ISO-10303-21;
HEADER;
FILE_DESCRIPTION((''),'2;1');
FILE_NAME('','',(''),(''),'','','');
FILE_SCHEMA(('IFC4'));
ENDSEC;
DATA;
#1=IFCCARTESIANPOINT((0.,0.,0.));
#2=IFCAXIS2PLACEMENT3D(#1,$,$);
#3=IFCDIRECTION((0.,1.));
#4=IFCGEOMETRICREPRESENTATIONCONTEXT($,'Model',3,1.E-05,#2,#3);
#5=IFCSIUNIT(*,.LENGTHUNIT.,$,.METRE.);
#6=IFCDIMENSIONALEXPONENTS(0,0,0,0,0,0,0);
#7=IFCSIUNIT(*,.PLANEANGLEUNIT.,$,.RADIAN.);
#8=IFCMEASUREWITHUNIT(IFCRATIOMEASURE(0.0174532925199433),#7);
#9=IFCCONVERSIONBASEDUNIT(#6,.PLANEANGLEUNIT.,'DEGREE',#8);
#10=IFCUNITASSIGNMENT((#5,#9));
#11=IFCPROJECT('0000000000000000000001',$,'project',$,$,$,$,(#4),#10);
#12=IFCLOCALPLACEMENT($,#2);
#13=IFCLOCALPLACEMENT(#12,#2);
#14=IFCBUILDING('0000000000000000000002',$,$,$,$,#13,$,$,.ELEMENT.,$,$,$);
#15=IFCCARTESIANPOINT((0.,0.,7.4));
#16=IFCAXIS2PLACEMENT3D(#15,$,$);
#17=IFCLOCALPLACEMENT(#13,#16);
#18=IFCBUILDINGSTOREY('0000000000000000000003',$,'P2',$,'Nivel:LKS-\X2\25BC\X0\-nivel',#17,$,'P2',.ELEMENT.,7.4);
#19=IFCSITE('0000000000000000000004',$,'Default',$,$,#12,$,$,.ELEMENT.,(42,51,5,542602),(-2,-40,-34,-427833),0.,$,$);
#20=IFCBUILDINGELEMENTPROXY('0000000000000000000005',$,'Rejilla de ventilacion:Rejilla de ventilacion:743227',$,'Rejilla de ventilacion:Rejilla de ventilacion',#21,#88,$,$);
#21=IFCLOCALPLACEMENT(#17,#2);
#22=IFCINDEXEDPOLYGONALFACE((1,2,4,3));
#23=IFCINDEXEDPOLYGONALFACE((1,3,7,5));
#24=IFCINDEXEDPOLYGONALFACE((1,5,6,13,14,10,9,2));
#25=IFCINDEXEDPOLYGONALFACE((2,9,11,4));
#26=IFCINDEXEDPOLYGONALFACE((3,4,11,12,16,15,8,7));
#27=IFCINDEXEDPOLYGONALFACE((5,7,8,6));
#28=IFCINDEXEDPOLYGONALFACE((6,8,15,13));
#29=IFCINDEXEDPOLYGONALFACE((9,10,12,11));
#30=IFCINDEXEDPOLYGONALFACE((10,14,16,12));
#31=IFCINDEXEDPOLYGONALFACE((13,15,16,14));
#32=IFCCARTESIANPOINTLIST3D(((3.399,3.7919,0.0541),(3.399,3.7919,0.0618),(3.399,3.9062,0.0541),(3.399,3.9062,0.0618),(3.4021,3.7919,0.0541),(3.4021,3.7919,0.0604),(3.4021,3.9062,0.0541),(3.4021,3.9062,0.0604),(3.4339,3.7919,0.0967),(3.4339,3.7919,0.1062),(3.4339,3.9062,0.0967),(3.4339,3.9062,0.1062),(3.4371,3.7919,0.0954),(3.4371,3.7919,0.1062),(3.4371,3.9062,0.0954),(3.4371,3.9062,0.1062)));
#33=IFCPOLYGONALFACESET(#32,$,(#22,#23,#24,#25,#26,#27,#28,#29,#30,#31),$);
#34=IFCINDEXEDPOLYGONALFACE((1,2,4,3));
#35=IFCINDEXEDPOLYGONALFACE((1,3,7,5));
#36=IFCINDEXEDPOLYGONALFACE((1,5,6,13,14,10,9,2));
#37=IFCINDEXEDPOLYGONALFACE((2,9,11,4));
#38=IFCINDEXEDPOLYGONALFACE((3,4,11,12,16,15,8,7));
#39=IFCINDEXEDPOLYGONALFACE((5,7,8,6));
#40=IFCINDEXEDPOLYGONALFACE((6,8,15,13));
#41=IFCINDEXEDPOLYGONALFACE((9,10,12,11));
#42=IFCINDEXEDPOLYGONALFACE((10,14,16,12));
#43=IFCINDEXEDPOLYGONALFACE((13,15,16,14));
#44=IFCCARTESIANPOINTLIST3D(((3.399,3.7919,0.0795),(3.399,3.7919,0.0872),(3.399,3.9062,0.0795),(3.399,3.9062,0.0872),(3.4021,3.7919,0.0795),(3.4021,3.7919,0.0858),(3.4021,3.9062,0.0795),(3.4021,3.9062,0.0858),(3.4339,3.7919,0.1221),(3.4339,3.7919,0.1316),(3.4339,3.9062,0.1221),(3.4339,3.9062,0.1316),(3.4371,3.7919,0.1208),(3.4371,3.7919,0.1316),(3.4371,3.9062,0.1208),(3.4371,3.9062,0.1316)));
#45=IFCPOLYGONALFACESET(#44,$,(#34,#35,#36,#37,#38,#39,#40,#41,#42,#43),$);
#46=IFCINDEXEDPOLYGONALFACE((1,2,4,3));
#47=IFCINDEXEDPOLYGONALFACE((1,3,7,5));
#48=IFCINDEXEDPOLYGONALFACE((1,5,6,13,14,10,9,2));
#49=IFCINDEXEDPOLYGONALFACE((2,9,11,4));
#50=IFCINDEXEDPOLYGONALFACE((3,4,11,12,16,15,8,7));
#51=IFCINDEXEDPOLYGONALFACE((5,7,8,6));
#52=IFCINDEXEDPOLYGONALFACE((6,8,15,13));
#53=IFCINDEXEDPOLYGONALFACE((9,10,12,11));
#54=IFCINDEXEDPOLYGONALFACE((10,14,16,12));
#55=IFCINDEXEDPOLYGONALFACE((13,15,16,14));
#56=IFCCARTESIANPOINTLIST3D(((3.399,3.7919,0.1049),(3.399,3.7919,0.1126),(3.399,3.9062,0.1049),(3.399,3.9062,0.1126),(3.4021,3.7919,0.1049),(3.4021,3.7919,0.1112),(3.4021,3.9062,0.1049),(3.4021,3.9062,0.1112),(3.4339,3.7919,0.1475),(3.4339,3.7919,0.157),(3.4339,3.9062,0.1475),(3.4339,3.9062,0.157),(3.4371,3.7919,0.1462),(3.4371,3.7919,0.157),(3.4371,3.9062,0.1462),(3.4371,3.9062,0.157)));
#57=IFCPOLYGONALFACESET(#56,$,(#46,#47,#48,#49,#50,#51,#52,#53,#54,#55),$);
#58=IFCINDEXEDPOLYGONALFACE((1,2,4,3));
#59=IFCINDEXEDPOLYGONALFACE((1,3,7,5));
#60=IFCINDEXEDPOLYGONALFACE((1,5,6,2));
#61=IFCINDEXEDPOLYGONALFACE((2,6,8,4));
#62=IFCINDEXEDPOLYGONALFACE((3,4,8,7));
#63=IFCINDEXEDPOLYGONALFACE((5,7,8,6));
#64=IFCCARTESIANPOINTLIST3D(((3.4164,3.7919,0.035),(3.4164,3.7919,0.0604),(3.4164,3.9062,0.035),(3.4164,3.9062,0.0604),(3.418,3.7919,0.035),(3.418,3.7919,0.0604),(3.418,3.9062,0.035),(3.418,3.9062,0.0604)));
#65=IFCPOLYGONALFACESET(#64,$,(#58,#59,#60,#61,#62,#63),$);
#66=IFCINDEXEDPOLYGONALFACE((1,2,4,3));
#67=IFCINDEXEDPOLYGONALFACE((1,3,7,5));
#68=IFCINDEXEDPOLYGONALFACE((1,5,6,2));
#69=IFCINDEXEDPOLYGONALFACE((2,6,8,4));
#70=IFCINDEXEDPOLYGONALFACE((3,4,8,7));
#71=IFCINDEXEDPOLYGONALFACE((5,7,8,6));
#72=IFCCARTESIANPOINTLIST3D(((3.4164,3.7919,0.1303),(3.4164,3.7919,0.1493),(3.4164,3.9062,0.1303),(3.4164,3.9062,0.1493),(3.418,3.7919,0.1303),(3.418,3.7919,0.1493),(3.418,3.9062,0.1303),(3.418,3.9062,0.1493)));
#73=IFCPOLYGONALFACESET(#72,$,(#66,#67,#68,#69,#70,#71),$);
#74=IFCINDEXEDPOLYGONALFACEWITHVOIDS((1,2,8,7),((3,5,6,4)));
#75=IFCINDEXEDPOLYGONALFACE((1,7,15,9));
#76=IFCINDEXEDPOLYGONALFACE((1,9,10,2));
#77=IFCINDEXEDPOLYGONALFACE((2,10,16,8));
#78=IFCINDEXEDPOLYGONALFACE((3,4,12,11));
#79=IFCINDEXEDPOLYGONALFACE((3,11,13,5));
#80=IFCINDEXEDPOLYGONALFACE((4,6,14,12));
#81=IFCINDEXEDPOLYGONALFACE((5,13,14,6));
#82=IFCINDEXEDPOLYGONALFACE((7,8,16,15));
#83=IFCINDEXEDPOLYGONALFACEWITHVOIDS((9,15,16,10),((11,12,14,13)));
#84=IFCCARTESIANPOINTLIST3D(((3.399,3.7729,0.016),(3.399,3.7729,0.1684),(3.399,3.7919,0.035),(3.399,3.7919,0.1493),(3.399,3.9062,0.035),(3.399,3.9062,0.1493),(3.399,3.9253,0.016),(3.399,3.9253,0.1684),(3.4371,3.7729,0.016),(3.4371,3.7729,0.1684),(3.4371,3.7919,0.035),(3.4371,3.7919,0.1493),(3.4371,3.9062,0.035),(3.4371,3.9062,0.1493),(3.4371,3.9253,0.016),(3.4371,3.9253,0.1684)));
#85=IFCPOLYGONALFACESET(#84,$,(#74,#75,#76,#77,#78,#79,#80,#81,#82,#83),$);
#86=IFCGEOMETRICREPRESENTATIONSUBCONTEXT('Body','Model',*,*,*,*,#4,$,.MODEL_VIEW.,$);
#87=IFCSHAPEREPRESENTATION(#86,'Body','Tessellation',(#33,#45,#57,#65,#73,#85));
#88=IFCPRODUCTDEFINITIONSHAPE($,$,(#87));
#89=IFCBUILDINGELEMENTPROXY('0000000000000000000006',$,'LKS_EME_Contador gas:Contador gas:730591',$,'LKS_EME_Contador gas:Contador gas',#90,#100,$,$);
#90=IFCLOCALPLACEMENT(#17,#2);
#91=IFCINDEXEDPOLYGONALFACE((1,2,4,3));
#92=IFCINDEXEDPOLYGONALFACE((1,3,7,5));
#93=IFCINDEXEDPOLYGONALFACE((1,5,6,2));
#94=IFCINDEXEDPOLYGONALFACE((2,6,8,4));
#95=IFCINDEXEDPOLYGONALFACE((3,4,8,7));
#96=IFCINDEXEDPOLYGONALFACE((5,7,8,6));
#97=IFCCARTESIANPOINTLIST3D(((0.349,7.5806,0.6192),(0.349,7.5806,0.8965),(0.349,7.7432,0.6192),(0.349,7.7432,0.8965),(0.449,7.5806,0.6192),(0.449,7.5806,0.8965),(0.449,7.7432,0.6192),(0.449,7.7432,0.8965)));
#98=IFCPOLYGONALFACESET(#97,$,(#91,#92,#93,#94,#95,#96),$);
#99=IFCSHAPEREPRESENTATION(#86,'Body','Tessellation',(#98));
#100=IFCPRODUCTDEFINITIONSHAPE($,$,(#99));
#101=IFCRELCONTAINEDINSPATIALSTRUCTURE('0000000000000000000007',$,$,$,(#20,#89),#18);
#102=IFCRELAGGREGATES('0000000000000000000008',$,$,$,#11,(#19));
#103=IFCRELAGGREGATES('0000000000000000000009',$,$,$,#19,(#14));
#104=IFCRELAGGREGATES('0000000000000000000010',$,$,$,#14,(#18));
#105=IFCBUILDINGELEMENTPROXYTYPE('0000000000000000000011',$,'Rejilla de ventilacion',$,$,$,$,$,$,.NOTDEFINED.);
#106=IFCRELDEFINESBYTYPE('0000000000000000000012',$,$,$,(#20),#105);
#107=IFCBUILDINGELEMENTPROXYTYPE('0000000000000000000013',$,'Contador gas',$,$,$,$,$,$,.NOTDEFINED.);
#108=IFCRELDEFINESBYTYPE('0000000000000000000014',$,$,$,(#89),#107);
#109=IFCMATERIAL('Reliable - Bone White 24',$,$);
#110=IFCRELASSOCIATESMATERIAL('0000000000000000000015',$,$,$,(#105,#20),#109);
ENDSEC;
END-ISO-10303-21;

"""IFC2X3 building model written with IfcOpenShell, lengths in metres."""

from ifc_helpers import new_model, entity, si_unit, converted_unit, direction, frame, frame_2d, origin, origin_2d_with_axis, place, context, subcontext, project, spatial, polyline, rectangle, outline, extrude, source, transform, mapped, material, type_object, type_shapes, element, save


model = new_model("IFC2X3")

# Units and contexts
model_context = context("Model", 3, precision=1e-05, world=origin(), true_north=direction((0.0, 1.0)))
body_context = subcontext(model_context, "Body", "Model", "MODEL_VIEW")
ifc_project = project(units=[si_unit("LENGTHUNIT", "METRE"), converted_unit("PLANEANGLEUNIT", "DEGREE", entity("IfcRatioMeasure", 0.0174532925199433), si_unit("PLANEANGLEUNIT", "RADIAN"), dimensions=[0, 0, 0, 0, 0, 0, 0])], contexts=[model_context])

# Site, building, storey
site_placement = place(None, origin())
site = spatial("IfcSite", under=ifc_project, at=site_placement, Name="Default", CompositionType="ELEMENT", RefLatitude=(42, 51, 5, 542602), RefLongitude=(-2, -40, -34, -427833), RefElevation=0.0)
building_placement = place(site_placement, origin())
building = spatial("IfcBuilding", under=site, at=building_placement, CompositionType="ELEMENT")
storey_placement = place(building_placement, frame((0.0, 0.0, 7.4)))
storey = spatial("IfcBuildingStorey", under=building, at=storey_placement, Name="P2", ObjectType="Nivel:LKS-▼-nivel", LongName="P2", CompositionType="ELEMENT", Elevation=7.4)

# Building element proxies
ifc_material_1 = material(Name="Reliable - Bone White 24")
building_element_proxy_type_1 = type_object("IfcBuildingElementProxyType", Name="Rejilla de ventilacion", PredefinedType="NOTDEFINED", material=ifc_material_1)
shared_shape_1 = source(origin(), body_context, "Body", "SweptSolid", [
    extrude(outline(polyline([(0.0173, 0.0159), (0.0269, 0.0159), (0.0269, 0.0191), (0.016, 0.0191), (-0.0189, -0.0159), (-0.0253, -0.0159), (-0.0253, -0.019), (-0.0176, -0.019), (0.0173, 0.0159)])), frame((-0.0571, 0.1, 1.435), z_axis=(1.0, 0.0, 0.0), x_axis=(0.0, 0.0, 1.0)), (0.0, 0.0, 1.0), 0.1143),
    extrude(outline(polyline([(0.0173, 0.0159), (0.0269, 0.0159), (0.0269, 0.0191), (0.016, 0.0191), (-0.0189, -0.0159), (-0.0253, -0.0159), (-0.0253, -0.019), (-0.0176, -0.019), (0.0173, 0.0159)])), frame((-0.0571, 0.1, 1.4604), z_axis=(1.0, 0.0, 0.0), x_axis=(0.0, 0.0, 1.0)), (0.0, 0.0, 1.0), 0.1143),
    extrude(outline(polyline([(0.0173, 0.0159), (0.0269, 0.0159), (0.0269, 0.0191), (0.016, 0.0191), (-0.0189, -0.0159), (-0.0253, -0.0159), (-0.0253, -0.019), (-0.0176, -0.019), (0.0173, 0.0159)])), frame((-0.0571, 0.1, 1.4858), z_axis=(1.0, 0.0, 0.0), x_axis=(0.0, 0.0, 1.0)), (0.0, 0.0, 1.0), 0.1143),
    extrude(rectangle(XDim=0.1143, YDim=0.0016, at=frame_2d((0.0, 0.0), x_axis=(1.0, 0.0))), frame((0.0, 0.1007, 1.3906), z_axis=(0.0, 0.0, 1.0), x_axis=(-1.0, 0.0, 0.0)), (0.0, 0.0, 1.0), 0.0254),
    extrude(rectangle(XDim=0.1143, YDim=0.0016, at=frame_2d((0.0, 0.0), x_axis=(1.0, 0.0))), frame((0.0, 0.1007, 1.4859), z_axis=(0.0, 0.0, 1.0), x_axis=(-1.0, 0.0, 0.0)), (0.0, 0.0, 1.0), 0.0191),
    extrude(outline(polyline([(-0.0762, -0.0762), (0.0762, -0.0762), (0.0762, 0.0762), (-0.0762, 0.0762), (-0.0762, -0.0762)]), holes=[polyline([(-0.0572, -0.0572), (-0.0572, 0.0572), (0.0572, 0.0572), (0.0572, -0.0572), (-0.0572, -0.0572)])]), frame((0.0, 0.0809, 1.4478), z_axis=(0.0, 1.0, 0.0), x_axis=(0.0, 0.0, 1.0)), (0.0, 0.0, 1.0), 0.0381),
])
type_shapes(building_element_proxy_type_1, [shared_shape_1])
proxy_1_placement = place(storey_placement, frame((3.518, 3.8491, -1.3556), z_axis=(0.0, 0.0, 1.0), x_axis=(0.0, 1.0, 0.0)))
element("IfcBuildingElementProxy", 1, at=proxy_1_placement, inside=storey, type_object=building_element_proxy_type_1, material=ifc_material_1, Name="Rejilla de ventilacion:Rejilla de ventilacion:743227", ObjectType="Rejilla de ventilacion:Rejilla de ventilacion", context=body_context, shape_type="MappedRepresentation", body=[
    mapped(shared_shape_1, transform((0.0, 0.0, 0.0), scale=1.0)),
])
building_element_proxy_type_2 = type_object("IfcBuildingElementProxyType", Name="Contador gas", PredefinedType="NOTDEFINED")
shared_shape_2 = source(origin(), body_context, "Body", "SweptSolid", [
    extrude(rectangle(XDim=0.1626, YDim=0.2773, at=origin_2d_with_axis()), frame((0.0, 0.0, 0.0), z_axis=(0.0, 0.0, 1.0), x_axis=(-1.0, 0.0, 0.0)), (0.0, 0.0, 1.0), 0.1),
])
type_shapes(building_element_proxy_type_2, [shared_shape_2])
proxy_2_placement = place(storey_placement, frame((0.349, 7.6619, 0.7578), z_axis=(1.0, 0.0, 0.0), x_axis=(0.0, 1.0, 0.0)))
element("IfcBuildingElementProxy", 2, at=proxy_2_placement, inside=storey, type_object=building_element_proxy_type_2, Name="LKS_EME_Contador gas:Contador gas:730591", ObjectType="LKS_EME_Contador gas:Contador gas", context=body_context, shape_type="MappedRepresentation", body=[
    mapped(shared_shape_2, transform((0.0, 0.0, 0.0), scale=1.0)),
])

save(model, "model.ifc")
